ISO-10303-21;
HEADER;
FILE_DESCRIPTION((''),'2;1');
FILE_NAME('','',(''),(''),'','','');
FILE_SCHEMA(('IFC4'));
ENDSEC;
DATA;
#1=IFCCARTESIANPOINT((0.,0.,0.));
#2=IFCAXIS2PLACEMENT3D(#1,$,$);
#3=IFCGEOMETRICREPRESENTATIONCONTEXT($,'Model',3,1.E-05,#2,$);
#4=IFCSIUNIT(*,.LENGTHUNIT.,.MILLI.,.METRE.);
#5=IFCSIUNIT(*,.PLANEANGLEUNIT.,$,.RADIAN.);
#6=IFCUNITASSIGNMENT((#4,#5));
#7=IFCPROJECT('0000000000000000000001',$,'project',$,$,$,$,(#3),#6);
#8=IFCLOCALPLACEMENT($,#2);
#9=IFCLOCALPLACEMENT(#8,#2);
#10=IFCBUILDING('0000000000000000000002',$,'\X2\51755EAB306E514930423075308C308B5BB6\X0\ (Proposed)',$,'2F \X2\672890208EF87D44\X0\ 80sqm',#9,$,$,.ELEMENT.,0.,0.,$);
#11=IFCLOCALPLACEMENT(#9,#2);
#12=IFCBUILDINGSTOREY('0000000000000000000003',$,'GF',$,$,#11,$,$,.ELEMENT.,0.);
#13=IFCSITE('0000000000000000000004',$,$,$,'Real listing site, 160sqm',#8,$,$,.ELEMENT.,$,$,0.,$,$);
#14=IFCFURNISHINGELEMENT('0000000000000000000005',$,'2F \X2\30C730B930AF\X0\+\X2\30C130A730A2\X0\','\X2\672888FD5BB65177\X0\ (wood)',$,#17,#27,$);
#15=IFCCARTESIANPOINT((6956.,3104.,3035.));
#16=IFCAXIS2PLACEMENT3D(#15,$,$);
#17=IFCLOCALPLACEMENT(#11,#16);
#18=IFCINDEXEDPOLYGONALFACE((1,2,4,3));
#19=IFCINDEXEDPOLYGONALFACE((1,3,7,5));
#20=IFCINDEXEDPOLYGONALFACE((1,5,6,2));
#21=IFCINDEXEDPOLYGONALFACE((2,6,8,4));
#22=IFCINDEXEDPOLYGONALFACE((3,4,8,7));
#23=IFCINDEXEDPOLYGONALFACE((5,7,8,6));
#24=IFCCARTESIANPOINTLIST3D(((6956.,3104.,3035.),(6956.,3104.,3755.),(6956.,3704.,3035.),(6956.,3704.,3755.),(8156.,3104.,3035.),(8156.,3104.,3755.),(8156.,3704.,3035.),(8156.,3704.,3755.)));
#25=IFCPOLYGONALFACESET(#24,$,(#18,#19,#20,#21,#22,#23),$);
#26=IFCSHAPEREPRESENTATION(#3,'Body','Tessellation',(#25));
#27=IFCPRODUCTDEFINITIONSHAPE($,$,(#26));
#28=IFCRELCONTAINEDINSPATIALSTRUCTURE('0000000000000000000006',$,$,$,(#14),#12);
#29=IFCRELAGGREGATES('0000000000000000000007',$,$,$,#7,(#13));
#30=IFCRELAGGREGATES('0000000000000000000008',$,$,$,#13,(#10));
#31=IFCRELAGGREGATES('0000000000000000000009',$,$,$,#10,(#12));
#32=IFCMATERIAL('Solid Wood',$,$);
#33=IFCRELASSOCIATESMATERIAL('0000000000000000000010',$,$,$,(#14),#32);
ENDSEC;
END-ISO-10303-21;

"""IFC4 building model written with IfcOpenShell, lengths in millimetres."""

from ifc_helpers import new_model, si_unit, frame, frame_2d, origin, place, context, project, spatial, rectangle, extrude, material, element, save


model = new_model("IFC4")

# Units and contexts
model_context = context("Model", 3, precision=1e-05, world=origin())
ifc_project = project(units=[si_unit("LENGTHUNIT", "METRE", prefix="MILLI"), si_unit("PLANEANGLEUNIT", "RADIAN")], contexts=[model_context])

# Site, building, storey
site_placement = place(None, origin())
site = spatial("IfcSite", under=ifc_project, at=site_placement, ObjectType="Real listing site, 160sqm", CompositionType="ELEMENT", RefElevation=0.0)
building_placement = place(site_placement, origin())
building = spatial("IfcBuilding", under=site, at=building_placement, Name="兵庫の光あふれる家 (Proposed)", ObjectType="2F 木造軸組 80sqm", CompositionType="ELEMENT", ElevationOfRefHeight=0.0, ElevationOfTerrain=0.0)
storey_placement = place(building_placement, origin())
storey = spatial("IfcBuildingStorey", under=building, at=storey_placement, Name="GF", CompositionType="ELEMENT", Elevation=0.0)

# Shared definitions
ifc_material_1 = material(Name="Solid Wood")

# Furnishing element
furnishing_1_placement = place(storey_placement, frame((6956.0, 3104.0, 3035.0)))
element("IfcFurnishingElement", 1, at=furnishing_1_placement, inside=storey, material=ifc_material_1, Name="2F デスク+チェア", Description="木製家具 (wood)", context=model_context, shape_type="SweptSolid", body=[
    extrude(rectangle(XDim=1200.0, YDim=600.0, at=frame_2d((600.0, 300.0))), frame((6956.0, 3104.0, 3035.0)), (0.0, 0.0, 1.0), 720.0),
])

save(model, "model.ifc")
